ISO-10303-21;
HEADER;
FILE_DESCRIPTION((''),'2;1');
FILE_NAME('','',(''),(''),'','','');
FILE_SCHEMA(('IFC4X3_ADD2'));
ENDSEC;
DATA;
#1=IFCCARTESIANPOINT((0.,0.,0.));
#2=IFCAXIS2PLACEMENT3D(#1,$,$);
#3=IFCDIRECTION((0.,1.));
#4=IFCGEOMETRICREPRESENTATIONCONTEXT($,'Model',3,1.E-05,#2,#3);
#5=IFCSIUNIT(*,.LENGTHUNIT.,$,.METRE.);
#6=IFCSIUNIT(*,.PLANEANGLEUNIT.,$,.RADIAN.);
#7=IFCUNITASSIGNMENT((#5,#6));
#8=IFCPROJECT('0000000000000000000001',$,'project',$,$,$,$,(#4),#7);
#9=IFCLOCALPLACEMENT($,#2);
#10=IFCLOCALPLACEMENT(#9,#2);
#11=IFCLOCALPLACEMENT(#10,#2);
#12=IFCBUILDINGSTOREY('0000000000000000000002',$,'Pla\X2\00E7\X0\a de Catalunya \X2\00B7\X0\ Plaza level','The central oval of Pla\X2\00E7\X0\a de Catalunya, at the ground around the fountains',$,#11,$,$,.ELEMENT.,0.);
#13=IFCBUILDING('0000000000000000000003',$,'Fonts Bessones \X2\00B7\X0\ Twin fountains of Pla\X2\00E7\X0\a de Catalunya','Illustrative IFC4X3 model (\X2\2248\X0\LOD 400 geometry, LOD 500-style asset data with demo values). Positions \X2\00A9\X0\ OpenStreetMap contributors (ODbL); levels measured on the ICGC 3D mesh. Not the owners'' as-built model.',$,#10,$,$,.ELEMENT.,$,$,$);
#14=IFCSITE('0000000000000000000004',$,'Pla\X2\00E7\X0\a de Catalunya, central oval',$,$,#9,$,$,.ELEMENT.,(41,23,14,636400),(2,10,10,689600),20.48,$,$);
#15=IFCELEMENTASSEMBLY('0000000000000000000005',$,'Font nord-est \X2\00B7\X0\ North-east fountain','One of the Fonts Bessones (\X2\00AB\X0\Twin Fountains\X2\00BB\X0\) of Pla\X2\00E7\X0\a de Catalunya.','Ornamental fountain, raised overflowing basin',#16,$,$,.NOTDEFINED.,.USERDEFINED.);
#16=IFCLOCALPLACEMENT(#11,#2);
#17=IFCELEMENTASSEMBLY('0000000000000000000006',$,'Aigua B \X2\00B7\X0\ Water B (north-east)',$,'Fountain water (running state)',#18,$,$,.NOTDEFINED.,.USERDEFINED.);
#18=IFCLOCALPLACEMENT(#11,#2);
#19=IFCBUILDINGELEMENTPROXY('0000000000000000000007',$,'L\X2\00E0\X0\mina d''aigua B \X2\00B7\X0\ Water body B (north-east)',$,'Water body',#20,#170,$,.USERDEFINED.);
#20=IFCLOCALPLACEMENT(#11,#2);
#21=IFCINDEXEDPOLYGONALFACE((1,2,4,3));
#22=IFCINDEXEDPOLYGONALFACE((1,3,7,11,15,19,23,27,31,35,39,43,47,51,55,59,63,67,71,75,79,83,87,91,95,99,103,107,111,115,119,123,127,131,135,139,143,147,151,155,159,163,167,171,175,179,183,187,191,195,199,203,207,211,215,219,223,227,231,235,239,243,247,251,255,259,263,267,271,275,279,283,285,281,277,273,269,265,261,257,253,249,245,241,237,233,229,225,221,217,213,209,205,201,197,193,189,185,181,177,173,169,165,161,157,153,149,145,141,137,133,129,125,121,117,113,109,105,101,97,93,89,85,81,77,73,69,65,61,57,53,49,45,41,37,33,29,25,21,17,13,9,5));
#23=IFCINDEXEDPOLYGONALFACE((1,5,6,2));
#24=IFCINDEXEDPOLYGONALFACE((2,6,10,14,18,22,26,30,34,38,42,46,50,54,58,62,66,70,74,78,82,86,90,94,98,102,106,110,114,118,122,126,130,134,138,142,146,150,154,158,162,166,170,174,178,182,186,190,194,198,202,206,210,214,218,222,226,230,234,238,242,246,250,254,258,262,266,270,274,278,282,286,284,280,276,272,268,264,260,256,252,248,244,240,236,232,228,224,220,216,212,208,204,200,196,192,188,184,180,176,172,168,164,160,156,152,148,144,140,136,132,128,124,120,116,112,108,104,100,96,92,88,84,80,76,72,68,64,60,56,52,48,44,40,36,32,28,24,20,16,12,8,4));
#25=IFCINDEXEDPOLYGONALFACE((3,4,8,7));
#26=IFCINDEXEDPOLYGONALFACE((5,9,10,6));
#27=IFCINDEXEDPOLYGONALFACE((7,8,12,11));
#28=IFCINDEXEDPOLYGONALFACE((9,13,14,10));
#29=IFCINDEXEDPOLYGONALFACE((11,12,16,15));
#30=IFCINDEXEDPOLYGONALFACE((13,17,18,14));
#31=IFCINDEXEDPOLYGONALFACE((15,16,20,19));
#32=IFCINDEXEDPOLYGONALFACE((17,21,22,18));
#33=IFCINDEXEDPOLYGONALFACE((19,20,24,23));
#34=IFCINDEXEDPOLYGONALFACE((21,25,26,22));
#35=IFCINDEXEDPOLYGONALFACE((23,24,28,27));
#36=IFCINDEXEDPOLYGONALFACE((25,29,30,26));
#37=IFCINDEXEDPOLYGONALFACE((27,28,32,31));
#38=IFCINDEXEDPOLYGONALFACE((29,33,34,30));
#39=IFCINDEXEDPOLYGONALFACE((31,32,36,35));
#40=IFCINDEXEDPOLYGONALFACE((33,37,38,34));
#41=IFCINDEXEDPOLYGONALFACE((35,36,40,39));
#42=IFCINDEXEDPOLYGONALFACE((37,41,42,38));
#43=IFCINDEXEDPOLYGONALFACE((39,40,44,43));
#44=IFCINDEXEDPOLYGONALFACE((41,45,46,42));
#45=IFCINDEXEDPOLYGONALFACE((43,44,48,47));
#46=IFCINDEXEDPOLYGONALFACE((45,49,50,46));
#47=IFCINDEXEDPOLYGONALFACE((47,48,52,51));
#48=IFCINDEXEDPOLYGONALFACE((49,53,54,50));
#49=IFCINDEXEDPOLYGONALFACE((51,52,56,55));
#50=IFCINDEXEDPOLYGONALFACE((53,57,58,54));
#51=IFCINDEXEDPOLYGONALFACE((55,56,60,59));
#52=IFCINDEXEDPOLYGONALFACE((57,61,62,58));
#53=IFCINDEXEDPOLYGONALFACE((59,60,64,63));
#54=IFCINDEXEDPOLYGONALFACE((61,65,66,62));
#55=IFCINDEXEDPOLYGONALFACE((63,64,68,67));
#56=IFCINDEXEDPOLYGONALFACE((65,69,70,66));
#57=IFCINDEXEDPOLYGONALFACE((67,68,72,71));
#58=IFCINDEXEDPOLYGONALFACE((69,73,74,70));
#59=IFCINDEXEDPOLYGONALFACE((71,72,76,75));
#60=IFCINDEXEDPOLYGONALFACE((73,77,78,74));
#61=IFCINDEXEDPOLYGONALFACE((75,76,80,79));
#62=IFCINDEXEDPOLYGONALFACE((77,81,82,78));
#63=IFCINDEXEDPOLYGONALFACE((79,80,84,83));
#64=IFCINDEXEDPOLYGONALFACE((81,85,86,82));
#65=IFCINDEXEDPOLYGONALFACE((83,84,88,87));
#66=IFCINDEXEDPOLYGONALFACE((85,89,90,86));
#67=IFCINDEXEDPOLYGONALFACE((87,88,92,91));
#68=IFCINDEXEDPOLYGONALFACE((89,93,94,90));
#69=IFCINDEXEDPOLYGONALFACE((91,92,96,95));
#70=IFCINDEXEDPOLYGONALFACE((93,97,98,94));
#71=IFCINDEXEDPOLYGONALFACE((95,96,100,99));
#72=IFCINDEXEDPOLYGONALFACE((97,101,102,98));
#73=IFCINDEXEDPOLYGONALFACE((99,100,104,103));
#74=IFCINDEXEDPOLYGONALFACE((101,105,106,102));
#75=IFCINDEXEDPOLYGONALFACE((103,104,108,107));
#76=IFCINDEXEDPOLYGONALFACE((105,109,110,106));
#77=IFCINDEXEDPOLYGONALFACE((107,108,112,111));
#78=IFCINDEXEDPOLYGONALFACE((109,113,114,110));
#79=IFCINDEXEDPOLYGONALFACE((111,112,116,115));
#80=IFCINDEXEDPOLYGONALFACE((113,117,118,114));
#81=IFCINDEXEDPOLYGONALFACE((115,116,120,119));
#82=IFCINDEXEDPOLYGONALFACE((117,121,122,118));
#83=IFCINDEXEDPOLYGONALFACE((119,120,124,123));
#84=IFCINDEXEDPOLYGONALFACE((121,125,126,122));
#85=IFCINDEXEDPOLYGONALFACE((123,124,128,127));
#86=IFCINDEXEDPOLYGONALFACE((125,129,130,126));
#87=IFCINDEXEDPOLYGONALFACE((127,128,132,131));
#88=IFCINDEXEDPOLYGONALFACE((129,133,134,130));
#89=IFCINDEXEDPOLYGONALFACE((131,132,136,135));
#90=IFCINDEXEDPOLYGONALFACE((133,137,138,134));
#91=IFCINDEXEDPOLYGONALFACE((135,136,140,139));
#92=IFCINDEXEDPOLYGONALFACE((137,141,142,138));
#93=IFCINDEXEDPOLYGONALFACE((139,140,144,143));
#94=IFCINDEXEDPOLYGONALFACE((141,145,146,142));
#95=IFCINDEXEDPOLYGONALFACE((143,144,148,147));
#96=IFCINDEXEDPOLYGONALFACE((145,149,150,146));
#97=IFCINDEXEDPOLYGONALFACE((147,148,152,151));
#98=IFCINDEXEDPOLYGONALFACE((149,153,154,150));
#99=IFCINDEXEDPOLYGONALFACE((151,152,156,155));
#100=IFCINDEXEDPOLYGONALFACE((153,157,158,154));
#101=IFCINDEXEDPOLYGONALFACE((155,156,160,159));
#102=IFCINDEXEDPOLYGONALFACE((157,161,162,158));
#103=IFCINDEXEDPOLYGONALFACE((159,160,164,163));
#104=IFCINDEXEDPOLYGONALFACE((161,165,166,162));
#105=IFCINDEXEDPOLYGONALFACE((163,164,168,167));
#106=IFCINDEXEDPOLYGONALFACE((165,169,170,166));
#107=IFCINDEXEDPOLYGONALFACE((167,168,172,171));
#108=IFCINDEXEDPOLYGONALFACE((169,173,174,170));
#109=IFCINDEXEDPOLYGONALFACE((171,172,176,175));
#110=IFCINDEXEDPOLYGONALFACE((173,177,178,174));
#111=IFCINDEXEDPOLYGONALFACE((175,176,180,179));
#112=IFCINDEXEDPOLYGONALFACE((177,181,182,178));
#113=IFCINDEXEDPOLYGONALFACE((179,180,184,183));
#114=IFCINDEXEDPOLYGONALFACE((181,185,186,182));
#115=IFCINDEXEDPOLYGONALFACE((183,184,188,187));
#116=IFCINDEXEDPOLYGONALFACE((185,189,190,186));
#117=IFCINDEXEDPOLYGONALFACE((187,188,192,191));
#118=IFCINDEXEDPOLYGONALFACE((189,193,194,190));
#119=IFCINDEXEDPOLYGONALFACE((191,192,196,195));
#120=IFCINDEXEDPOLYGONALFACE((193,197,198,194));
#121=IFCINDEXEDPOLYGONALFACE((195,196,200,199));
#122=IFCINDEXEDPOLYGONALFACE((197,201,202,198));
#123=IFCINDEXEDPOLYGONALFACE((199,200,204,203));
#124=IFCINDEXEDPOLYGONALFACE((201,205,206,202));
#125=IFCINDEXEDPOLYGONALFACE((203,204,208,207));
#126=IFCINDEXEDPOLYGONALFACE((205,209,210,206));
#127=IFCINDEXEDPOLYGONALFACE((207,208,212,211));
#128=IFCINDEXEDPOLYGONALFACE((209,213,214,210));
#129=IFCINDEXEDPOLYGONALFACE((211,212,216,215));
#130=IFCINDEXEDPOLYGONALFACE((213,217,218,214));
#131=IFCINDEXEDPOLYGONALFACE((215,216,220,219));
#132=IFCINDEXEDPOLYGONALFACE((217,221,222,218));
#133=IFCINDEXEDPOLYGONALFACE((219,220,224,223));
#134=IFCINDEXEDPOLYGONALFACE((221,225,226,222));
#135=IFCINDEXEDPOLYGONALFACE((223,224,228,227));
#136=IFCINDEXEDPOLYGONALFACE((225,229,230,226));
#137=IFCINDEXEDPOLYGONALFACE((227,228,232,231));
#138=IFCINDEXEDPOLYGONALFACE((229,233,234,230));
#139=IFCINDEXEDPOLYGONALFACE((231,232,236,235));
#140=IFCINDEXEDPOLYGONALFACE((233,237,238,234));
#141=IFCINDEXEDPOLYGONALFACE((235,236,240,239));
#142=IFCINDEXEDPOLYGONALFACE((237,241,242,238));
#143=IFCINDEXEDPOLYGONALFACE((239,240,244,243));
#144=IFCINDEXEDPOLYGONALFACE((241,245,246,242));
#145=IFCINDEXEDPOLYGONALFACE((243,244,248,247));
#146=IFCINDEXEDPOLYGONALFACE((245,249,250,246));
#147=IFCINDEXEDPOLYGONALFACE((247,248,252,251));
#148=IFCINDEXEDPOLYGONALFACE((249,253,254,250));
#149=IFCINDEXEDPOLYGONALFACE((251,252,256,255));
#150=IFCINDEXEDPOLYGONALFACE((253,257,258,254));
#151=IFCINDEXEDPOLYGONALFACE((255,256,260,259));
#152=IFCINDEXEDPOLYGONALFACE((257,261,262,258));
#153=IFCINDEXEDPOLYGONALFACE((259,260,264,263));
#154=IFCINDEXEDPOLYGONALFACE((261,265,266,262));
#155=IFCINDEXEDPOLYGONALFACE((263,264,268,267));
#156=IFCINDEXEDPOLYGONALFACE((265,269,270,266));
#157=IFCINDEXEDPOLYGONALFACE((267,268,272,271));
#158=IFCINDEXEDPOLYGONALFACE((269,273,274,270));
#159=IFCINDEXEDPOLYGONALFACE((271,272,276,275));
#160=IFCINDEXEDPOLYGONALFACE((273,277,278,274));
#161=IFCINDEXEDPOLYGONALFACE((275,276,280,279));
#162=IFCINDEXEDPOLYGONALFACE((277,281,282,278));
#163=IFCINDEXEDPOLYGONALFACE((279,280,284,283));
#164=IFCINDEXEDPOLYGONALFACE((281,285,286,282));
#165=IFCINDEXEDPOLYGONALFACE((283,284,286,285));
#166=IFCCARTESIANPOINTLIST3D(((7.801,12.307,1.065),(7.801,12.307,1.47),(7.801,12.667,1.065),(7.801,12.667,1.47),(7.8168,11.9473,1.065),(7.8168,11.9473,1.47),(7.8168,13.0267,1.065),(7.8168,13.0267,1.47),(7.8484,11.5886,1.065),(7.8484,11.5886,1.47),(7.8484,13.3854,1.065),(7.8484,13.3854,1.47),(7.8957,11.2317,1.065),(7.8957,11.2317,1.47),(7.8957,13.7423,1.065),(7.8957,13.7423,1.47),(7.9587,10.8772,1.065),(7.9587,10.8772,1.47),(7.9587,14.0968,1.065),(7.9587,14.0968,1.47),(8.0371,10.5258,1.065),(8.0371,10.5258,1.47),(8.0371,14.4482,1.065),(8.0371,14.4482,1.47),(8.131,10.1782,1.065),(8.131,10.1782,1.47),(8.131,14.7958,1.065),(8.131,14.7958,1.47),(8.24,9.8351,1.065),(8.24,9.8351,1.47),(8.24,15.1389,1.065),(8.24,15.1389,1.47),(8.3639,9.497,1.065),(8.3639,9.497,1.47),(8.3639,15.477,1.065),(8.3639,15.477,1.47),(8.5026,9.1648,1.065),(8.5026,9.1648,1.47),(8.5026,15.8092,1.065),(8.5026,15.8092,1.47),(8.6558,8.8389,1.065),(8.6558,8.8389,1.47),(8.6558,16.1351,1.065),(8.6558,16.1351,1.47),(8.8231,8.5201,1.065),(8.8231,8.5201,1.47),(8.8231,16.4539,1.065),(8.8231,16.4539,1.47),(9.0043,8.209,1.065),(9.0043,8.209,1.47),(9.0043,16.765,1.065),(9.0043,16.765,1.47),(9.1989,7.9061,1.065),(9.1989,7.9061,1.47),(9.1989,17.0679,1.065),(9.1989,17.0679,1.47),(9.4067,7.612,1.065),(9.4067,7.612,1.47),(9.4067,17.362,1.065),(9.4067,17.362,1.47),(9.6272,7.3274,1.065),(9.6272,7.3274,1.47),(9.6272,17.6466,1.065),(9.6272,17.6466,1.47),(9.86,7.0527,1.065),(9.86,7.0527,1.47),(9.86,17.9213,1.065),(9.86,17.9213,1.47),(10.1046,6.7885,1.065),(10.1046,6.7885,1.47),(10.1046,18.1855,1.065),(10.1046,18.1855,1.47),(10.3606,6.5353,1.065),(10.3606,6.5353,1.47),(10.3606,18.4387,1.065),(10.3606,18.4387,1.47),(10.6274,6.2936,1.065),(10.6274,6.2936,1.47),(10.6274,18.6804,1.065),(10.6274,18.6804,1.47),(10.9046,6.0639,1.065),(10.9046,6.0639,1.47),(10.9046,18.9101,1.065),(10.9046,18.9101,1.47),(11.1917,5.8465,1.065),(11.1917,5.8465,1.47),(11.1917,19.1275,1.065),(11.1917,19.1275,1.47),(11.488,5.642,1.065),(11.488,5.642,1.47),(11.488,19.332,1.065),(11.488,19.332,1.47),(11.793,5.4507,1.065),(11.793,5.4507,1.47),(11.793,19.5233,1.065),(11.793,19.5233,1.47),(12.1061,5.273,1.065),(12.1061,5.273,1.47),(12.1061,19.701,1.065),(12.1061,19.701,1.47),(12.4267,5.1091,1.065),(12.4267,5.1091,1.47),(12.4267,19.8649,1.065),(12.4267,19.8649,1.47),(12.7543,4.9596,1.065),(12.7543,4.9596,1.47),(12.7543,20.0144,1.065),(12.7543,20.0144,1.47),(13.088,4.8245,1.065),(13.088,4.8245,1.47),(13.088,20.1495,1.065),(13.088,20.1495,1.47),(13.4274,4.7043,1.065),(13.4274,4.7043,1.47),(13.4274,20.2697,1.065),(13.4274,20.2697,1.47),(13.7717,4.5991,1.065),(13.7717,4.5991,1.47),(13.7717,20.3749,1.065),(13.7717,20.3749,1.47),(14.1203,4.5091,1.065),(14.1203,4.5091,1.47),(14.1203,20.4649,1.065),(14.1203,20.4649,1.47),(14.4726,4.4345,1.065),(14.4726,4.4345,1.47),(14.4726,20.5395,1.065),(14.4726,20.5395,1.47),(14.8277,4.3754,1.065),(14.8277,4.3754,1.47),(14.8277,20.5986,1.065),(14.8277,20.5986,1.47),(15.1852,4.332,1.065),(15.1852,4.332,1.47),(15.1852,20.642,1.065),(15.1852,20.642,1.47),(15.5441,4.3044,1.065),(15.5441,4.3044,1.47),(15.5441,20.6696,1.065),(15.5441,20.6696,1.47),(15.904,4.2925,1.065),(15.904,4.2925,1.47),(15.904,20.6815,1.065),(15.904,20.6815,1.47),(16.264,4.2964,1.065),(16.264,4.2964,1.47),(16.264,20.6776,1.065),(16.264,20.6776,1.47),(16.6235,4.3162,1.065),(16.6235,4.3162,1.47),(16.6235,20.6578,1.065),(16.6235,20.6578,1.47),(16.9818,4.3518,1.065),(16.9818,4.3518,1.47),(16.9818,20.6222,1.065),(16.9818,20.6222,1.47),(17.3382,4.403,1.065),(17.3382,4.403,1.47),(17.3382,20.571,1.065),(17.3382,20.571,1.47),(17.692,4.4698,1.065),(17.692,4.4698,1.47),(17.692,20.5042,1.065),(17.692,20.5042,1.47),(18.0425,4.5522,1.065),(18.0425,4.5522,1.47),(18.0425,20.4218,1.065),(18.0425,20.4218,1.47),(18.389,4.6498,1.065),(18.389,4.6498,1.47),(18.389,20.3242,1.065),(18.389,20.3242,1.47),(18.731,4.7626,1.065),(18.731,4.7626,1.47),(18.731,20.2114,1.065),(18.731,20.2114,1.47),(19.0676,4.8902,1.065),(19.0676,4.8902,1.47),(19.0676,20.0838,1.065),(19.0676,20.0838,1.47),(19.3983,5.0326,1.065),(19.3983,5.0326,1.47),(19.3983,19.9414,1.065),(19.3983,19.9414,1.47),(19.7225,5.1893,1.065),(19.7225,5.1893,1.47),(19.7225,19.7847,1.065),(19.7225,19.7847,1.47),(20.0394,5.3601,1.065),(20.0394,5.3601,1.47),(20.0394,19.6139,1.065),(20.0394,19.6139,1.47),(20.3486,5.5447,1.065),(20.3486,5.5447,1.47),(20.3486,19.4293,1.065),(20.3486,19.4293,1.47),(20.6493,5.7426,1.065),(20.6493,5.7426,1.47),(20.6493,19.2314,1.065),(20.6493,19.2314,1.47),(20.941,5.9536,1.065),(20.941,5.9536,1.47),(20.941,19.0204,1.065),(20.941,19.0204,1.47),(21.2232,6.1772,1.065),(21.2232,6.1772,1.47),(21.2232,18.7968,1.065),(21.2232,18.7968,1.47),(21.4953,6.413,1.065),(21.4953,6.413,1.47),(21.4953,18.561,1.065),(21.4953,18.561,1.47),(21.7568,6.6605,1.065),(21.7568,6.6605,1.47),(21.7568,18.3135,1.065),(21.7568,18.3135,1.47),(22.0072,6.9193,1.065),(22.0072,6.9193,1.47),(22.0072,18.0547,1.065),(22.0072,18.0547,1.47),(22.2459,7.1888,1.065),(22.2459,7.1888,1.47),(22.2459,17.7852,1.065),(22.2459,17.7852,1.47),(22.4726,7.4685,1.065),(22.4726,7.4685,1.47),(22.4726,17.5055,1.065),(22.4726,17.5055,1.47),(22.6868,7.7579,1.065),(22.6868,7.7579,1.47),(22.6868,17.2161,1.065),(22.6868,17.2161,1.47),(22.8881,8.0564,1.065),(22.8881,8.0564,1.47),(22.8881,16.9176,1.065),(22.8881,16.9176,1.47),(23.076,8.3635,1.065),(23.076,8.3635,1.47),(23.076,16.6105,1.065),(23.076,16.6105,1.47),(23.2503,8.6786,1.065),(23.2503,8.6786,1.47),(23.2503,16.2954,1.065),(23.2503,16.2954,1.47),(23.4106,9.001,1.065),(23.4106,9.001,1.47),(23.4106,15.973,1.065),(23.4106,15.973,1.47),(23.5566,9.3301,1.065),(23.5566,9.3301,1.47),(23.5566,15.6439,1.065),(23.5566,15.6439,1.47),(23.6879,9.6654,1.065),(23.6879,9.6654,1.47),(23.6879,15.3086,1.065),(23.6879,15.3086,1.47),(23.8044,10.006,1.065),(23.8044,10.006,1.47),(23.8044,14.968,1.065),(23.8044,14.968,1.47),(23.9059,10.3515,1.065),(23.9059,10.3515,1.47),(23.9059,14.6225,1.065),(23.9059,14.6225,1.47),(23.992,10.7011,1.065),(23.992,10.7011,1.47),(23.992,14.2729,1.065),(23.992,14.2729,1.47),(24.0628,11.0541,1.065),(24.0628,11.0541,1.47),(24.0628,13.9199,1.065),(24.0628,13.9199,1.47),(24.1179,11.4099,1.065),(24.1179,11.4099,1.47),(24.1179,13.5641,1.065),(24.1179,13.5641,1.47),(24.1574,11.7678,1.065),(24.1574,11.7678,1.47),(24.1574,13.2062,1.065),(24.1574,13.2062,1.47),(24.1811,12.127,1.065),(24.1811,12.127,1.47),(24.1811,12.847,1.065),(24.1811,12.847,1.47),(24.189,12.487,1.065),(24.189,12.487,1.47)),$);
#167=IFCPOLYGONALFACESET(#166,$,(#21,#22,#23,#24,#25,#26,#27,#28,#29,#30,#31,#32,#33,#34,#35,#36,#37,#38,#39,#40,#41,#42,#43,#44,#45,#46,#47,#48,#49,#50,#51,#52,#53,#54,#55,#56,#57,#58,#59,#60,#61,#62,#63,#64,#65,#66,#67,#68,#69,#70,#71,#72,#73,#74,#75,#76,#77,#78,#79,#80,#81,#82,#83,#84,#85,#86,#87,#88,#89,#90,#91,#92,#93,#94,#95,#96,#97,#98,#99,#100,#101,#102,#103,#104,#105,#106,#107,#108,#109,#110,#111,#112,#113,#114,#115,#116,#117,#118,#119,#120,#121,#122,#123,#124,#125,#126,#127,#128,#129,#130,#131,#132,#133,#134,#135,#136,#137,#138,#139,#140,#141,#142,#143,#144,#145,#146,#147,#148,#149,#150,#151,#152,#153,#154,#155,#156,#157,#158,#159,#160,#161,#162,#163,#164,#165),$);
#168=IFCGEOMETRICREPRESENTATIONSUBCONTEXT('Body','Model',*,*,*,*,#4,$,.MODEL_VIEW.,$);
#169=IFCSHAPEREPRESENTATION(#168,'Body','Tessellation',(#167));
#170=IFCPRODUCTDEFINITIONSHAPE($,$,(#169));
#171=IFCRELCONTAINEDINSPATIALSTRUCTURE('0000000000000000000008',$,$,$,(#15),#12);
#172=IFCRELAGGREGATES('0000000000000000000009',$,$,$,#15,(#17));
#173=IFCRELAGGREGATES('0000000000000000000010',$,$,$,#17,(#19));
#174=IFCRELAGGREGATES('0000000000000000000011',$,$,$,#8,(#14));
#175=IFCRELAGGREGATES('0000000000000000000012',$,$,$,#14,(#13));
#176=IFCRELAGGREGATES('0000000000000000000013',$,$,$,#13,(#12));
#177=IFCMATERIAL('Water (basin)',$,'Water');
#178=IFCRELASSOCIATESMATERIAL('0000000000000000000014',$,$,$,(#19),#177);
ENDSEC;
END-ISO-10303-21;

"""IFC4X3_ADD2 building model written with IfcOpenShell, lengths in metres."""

from ifc_helpers import new_model, si_unit, direction, frame, origin, origin_2d_with_axis, place, context, subcontext, project, spatial, circle, extrude, material, element, aggregate, save


model = new_model("IFC4X3_ADD2")

# Units and contexts
model_context = context("Model", 3, precision=1e-05, world=origin(), true_north=direction((0.0, 1.0)))
body_context = subcontext(model_context, "Body", "Model", "MODEL_VIEW")
ifc_project = project(units=[si_unit("LENGTHUNIT", "METRE"), si_unit("PLANEANGLEUNIT", "RADIAN")], contexts=[model_context])

# Site, building, storey
site_placement = place(None, origin())
site = spatial("IfcSite", under=ifc_project, at=site_placement, Name="Plaça de Catalunya, central oval", CompositionType="ELEMENT", RefLatitude=(41, 23, 14, 636400), RefLongitude=(2, 10, 10, 689600), RefElevation=20.48)
building_placement = place(site_placement, origin())
building = spatial("IfcBuilding", under=site, at=building_placement, Name="Fonts Bessones · Twin fountains of Plaça de Catalunya", Description="Illustrative IFC4X3 model (≈LOD 400 geometry, LOD 500-style asset data with demo values). Positions © OpenStreetMap contributors (ODbL); levels measured on the ICGC 3D mesh. Not the owners' as-built model.", CompositionType="ELEMENT")
storey_placement = place(building_placement, origin())
storey = spatial("IfcBuildingStorey", under=building, at=storey_placement, Name="Plaça de Catalunya · Plaza level", Description="The central oval of Plaça de Catalunya, at the ground around the fountains", CompositionType="ELEMENT", Elevation=0.0)

# Element assembly
assembly_1_placement = place(building_placement, origin())
assembly_1 = element("IfcElementAssembly", 1, at=assembly_1_placement, inside=storey, Name="Font nord-est · North-east fountain", Description="One of the Fonts Bessones («Twin Fountains») of Plaça de Catalunya.", ObjectType="Ornamental fountain, raised overflowing basin", AssemblyPlace="NOTDEFINED", PredefinedType="USERDEFINED")

# Element assembly
assembly_2_placement = place(building_placement, origin())
assembly_2 = element("IfcElementAssembly", 2, at=assembly_2_placement, Name="Aigua B · Water B (north-east)", ObjectType="Fountain water (running state)", AssemblyPlace="NOTDEFINED", PredefinedType="USERDEFINED")
aggregate(assembly_1, [assembly_2])

# Building element proxy
ifc_material_1 = material(Name="Water (basin)", Category="Water")
proxy_placement = place(building_placement, origin())
proxy = element("IfcBuildingElementProxy", 3, at=proxy_placement, material=ifc_material_1, Name="Làmina d'aigua B · Water body B (north-east)", ObjectType="Water body", PredefinedType="USERDEFINED", context=body_context, shape_type="SweptSolid", body=[
    extrude(circle(Radius=8.195, at=origin_2d_with_axis()), frame((15.994, 12.487, 1.065)), (0.0, 0.0, 1.0), 0.405),
])
aggregate(assembly_2, [proxy])

save(model, "model.ifc")
